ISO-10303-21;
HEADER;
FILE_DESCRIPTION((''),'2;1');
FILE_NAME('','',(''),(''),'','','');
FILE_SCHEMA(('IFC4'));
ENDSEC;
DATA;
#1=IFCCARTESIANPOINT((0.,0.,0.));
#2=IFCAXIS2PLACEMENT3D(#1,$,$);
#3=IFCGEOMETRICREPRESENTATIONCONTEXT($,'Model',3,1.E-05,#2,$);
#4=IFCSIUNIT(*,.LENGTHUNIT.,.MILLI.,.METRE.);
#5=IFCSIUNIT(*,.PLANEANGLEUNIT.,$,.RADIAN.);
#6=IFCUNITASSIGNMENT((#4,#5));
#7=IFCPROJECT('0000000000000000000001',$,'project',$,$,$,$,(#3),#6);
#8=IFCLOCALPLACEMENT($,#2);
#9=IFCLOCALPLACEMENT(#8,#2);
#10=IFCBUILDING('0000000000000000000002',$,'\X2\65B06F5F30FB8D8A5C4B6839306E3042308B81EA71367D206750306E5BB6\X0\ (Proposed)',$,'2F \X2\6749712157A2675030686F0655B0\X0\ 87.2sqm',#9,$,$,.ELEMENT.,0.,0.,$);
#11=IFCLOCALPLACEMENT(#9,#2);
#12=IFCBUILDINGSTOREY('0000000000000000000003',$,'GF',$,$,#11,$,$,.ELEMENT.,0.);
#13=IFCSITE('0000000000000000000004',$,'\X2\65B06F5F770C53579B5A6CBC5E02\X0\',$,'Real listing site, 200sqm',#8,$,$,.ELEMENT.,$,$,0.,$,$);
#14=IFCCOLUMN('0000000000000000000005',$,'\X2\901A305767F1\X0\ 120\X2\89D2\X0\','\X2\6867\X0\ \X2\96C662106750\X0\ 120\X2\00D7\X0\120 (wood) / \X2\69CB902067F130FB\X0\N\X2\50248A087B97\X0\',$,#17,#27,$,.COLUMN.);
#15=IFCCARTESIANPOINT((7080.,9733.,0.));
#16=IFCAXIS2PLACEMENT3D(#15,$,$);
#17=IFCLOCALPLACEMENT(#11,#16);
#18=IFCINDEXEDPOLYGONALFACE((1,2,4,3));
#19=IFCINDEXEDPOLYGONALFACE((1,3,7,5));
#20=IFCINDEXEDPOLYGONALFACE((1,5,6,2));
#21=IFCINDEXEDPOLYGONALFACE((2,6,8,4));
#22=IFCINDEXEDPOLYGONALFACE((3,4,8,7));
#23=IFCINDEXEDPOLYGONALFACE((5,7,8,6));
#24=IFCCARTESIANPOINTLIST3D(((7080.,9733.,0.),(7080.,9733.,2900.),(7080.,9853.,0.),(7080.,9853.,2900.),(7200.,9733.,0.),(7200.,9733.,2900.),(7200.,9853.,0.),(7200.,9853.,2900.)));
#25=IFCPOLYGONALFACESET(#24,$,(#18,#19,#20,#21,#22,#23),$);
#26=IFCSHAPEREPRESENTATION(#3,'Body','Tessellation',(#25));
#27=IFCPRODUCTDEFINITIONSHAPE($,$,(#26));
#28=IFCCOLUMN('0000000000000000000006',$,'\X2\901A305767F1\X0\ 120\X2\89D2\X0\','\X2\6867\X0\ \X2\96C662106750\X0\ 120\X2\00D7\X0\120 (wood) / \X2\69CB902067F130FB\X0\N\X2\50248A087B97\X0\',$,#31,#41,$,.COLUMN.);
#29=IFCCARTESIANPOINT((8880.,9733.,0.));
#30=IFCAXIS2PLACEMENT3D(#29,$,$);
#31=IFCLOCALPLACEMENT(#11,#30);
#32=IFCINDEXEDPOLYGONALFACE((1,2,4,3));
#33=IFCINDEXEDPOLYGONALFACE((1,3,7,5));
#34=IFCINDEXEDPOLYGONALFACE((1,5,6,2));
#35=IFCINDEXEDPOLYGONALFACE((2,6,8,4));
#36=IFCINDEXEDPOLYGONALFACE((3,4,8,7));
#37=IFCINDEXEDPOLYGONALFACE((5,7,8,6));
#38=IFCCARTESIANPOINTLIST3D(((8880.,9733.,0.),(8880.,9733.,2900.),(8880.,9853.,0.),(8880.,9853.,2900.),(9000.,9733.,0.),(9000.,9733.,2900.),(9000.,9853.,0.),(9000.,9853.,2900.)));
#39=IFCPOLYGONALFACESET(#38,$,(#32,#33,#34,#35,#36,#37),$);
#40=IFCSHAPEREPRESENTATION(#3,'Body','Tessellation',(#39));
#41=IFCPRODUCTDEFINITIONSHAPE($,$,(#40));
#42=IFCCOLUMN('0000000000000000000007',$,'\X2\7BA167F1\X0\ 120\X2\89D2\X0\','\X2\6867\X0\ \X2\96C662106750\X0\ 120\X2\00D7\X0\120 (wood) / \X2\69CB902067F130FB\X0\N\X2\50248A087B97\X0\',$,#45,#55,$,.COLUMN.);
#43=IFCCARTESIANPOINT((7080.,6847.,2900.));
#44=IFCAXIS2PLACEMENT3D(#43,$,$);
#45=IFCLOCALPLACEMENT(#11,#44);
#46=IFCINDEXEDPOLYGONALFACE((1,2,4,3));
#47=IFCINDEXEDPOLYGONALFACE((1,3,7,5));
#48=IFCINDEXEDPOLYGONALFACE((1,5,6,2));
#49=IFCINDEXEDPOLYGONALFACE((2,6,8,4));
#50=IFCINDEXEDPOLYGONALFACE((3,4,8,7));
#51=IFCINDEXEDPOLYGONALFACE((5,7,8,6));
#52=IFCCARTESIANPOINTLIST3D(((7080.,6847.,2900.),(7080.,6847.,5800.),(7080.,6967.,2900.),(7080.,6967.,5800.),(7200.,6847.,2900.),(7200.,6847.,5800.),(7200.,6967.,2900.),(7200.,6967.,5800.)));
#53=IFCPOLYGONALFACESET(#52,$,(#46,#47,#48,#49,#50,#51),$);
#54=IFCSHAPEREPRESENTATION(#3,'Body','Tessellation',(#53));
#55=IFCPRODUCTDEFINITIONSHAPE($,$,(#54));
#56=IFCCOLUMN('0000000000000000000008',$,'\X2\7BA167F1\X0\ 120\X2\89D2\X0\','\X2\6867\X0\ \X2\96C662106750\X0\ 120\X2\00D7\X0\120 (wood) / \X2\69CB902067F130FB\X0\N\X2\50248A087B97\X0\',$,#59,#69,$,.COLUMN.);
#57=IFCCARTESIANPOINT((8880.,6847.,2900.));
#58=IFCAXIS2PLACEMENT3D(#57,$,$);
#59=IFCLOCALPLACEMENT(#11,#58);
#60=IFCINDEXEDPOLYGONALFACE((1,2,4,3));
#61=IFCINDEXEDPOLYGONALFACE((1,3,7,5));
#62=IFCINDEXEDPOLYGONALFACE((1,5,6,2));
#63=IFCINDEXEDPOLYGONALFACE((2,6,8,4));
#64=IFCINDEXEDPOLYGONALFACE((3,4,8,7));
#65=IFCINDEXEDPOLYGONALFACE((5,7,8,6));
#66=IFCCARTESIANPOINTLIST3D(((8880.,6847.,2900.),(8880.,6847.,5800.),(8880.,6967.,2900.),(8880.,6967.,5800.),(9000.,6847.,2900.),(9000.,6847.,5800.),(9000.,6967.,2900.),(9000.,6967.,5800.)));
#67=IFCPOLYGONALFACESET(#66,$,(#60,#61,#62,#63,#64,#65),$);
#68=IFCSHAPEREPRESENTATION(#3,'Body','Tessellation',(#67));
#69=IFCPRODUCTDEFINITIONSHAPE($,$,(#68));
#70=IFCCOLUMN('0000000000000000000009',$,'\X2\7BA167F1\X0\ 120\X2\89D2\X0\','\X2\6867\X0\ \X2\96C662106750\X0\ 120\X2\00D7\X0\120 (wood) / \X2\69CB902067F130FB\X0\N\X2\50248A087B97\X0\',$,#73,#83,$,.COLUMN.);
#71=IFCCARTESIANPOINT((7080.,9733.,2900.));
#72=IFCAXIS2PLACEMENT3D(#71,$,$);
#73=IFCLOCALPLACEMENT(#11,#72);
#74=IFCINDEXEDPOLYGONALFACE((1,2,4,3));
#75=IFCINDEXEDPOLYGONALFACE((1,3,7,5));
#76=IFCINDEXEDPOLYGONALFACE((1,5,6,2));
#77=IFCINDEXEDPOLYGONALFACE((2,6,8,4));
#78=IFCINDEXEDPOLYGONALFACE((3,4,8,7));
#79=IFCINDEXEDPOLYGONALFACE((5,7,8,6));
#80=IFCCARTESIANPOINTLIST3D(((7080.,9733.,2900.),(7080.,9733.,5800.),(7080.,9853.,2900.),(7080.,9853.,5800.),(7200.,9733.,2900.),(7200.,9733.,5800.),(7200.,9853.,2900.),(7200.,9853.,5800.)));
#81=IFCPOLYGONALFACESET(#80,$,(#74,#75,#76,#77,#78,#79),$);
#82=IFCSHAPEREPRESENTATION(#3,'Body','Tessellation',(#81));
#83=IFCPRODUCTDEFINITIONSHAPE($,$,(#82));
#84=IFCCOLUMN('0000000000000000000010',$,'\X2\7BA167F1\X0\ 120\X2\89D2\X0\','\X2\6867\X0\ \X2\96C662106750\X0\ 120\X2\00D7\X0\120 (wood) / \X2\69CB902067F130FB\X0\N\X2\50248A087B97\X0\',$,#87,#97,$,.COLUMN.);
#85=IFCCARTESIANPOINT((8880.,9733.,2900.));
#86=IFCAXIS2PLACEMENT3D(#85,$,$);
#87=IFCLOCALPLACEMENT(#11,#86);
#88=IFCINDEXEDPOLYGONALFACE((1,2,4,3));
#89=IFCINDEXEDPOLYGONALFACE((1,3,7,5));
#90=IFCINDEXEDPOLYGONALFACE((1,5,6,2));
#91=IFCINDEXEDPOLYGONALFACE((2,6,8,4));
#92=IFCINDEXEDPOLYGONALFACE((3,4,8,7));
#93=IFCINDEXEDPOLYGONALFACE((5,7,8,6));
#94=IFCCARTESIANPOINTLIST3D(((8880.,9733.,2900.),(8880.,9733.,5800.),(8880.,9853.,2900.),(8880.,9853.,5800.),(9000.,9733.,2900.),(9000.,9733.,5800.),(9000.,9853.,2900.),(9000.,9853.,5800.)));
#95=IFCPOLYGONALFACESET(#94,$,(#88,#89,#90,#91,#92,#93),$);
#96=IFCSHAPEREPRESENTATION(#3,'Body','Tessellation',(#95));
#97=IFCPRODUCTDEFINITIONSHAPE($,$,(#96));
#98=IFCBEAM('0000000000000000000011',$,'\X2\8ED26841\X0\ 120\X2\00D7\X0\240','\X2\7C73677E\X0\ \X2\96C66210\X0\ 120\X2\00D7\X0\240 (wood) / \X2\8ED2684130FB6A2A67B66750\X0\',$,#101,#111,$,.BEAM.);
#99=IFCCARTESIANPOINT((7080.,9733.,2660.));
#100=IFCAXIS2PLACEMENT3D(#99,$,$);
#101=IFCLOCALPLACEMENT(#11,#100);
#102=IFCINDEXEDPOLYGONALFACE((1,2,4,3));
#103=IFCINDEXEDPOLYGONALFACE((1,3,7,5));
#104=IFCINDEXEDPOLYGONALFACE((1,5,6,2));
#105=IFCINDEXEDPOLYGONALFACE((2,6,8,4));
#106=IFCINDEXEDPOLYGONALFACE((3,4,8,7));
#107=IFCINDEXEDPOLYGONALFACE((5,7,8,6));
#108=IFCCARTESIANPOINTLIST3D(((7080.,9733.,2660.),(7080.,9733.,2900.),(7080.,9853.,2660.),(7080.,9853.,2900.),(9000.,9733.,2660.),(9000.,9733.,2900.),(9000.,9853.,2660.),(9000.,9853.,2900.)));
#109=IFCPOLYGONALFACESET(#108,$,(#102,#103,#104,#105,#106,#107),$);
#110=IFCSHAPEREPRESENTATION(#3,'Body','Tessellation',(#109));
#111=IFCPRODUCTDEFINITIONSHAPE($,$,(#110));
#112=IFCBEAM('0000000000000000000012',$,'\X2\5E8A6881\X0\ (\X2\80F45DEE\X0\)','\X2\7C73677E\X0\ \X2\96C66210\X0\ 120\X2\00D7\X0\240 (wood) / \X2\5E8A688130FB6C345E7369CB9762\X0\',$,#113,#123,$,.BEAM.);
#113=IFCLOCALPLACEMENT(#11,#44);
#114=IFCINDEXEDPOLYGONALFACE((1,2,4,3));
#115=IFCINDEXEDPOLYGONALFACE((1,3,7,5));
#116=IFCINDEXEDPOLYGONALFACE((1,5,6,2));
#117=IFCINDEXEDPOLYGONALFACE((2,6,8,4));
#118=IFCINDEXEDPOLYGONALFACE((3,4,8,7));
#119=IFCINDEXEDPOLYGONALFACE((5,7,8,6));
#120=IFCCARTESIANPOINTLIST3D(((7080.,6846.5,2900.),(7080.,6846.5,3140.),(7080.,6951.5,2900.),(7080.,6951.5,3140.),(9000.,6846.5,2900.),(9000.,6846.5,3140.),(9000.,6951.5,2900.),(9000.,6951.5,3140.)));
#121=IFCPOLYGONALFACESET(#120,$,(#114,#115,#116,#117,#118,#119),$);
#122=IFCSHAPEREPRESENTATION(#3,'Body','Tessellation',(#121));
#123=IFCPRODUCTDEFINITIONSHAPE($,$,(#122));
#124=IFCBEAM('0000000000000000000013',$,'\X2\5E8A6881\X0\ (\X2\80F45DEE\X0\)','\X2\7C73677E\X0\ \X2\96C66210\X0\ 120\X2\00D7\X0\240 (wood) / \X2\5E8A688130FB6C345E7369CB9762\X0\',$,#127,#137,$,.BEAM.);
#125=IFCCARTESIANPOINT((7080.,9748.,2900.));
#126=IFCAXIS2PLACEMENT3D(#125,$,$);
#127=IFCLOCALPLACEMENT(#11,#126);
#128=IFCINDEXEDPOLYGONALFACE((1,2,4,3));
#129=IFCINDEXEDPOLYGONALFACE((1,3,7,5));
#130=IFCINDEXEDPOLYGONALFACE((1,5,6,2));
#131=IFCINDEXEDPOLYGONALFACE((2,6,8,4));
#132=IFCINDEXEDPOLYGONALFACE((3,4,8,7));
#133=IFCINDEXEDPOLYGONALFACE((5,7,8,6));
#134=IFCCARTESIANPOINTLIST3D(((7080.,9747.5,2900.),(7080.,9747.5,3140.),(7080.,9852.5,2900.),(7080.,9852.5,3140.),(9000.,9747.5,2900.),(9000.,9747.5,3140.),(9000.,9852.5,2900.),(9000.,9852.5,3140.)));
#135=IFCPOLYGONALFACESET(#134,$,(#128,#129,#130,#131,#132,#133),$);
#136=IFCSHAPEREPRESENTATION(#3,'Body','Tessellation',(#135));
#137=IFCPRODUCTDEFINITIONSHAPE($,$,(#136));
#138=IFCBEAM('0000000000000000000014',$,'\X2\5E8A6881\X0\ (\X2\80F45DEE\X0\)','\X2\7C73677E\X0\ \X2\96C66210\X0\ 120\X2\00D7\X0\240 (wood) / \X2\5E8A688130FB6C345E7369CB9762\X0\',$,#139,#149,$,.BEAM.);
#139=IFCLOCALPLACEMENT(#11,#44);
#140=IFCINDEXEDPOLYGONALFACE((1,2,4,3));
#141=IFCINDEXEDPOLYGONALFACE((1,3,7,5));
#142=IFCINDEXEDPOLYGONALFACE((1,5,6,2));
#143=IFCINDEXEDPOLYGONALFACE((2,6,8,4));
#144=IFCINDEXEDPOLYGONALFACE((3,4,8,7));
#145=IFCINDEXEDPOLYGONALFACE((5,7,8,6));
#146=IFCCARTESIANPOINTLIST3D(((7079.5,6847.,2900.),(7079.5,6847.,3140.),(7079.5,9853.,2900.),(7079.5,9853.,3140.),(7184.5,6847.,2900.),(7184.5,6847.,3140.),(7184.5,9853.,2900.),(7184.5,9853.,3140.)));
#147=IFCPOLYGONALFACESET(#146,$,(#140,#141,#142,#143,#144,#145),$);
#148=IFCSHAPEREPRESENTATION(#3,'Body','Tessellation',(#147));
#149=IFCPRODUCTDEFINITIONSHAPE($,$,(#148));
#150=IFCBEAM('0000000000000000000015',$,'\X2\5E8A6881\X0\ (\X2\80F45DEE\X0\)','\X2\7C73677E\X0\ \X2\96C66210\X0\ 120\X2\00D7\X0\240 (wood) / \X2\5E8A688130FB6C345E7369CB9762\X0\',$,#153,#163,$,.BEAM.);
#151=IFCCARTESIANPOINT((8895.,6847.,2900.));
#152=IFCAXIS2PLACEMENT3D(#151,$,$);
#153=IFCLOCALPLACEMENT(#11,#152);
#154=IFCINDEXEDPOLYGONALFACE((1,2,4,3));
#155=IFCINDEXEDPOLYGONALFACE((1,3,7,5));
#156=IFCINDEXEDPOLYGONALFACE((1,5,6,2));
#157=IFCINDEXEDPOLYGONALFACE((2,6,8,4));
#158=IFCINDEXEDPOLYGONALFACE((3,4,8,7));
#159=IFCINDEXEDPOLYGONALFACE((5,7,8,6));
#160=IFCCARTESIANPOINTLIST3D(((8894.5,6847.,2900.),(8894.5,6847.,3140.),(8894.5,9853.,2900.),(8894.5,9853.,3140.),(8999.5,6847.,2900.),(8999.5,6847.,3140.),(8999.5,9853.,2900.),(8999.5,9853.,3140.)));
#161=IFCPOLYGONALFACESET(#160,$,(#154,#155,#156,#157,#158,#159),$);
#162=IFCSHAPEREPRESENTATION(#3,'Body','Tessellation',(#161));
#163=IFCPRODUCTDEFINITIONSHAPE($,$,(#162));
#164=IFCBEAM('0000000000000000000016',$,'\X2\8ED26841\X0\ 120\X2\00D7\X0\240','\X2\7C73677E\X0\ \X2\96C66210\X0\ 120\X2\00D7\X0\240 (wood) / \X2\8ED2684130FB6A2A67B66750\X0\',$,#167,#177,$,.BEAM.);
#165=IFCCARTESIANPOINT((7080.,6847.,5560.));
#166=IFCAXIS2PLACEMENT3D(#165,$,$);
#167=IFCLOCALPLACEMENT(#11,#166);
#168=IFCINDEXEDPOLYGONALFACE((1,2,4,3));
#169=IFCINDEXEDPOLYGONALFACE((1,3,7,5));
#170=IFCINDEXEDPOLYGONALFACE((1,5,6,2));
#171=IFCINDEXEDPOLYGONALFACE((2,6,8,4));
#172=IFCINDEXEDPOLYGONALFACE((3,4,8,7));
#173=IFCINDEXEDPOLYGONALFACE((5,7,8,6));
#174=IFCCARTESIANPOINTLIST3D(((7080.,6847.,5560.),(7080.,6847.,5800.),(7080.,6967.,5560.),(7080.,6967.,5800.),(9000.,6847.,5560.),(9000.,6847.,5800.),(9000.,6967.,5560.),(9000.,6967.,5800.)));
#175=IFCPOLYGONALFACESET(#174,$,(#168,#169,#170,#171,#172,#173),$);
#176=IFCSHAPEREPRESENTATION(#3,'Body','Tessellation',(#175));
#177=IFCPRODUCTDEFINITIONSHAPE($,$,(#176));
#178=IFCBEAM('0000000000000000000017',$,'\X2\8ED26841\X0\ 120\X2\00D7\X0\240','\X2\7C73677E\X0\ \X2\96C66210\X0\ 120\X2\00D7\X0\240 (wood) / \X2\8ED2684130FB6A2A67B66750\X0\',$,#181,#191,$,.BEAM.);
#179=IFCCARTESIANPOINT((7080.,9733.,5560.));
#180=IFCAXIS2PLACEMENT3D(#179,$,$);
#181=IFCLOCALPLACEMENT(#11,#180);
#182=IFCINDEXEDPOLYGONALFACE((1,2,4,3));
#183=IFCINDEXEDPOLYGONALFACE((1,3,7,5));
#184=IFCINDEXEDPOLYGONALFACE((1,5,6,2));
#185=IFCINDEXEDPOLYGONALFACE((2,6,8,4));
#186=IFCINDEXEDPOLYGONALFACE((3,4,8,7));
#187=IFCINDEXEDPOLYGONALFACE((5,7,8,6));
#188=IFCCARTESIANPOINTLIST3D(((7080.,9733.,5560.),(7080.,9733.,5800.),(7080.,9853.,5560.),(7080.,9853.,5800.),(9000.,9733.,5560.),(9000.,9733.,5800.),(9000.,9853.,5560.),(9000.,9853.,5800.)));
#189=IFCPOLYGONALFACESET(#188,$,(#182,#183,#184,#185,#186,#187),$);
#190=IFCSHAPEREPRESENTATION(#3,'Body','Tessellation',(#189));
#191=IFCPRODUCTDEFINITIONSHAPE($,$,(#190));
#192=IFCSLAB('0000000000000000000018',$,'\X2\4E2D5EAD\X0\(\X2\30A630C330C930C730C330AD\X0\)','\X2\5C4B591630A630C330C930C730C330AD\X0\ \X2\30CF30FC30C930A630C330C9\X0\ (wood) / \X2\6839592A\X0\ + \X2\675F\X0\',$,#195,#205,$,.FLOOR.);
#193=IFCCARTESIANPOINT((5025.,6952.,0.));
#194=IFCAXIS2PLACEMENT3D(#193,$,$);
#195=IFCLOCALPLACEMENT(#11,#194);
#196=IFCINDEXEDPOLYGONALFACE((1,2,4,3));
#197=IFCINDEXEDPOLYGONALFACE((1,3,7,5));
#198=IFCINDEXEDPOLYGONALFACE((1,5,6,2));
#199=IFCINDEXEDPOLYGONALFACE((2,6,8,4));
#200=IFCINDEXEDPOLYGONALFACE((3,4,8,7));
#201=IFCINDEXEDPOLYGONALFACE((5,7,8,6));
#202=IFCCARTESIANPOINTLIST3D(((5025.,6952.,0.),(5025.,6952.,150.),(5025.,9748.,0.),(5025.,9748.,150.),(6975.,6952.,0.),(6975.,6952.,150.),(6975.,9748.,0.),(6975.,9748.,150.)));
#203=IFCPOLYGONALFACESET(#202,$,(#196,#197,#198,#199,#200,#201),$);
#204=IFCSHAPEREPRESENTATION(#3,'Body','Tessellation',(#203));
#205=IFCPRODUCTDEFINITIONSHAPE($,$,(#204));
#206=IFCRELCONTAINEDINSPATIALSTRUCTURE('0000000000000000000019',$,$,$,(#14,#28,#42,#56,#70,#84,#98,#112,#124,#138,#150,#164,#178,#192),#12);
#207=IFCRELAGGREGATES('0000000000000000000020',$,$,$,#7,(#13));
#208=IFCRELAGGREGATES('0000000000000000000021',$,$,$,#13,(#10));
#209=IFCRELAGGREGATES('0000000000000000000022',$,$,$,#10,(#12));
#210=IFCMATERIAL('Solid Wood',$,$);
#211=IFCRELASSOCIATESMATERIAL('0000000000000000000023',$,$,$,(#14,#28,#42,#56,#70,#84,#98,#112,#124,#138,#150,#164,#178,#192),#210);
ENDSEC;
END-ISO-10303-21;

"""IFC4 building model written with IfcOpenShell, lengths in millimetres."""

from ifc_helpers import new_model, si_unit, frame, frame_2d, origin, place, context, project, spatial, rectangle, extrude, material, element, save


model = new_model("IFC4")

# Units and contexts
model_context = context("Model", 3, precision=1e-05, world=origin())
ifc_project = project(units=[si_unit("LENGTHUNIT", "METRE", prefix="MILLI"), si_unit("PLANEANGLEUNIT", "RADIAN")], contexts=[model_context])

# Site, building, storey
site_placement = place(None, origin())
site = spatial("IfcSite", under=ifc_project, at=site_placement, Name="新潟県南魚沼市", ObjectType="Real listing site, 200sqm", CompositionType="ELEMENT", RefElevation=0.0)
building_placement = place(site_placement, origin())
building = spatial("IfcBuilding", under=site, at=building_placement, Name="新潟・越屋根のある自然素材の家 (Proposed)", ObjectType="2F 杉無垢材と漆喰 87.2sqm", CompositionType="ELEMENT", ElevationOfRefHeight=0.0, ElevationOfTerrain=0.0)
storey_placement = place(building_placement, origin())
storey = spatial("IfcBuildingStorey", under=building, at=storey_placement, Name="GF", CompositionType="ELEMENT", Elevation=0.0)

# Columns
ifc_material_1 = material(Name="Solid Wood")
column_1_placement = place(storey_placement, frame((7080.0, 9733.0, 0.0)))
element("IfcColumn", 1, at=column_1_placement, inside=storey, material=ifc_material_1, Name="通し柱 120角", Description="桧 集成材 120×120 (wood) / 構造柱・N値計算", PredefinedType="COLUMN", context=model_context, shape_type="SweptSolid", body=[
    extrude(rectangle(XDim=120.0, YDim=120.0, at=frame_2d((60.0, 60.0))), frame((7080.0, 9733.0, 0.0)), (0.0, 0.0, 1.0), 2900.0),
])
column_2_placement = place(storey_placement, frame((8880.0, 9733.0, 0.0)))
element("IfcColumn", 2, at=column_2_placement, inside=storey, material=ifc_material_1, Name="通し柱 120角", Description="桧 集成材 120×120 (wood) / 構造柱・N値計算", PredefinedType="COLUMN", context=model_context, shape_type="SweptSolid", body=[
    extrude(rectangle(XDim=120.0, YDim=120.0, at=frame_2d((60.0, 60.0))), frame((8880.0, 9733.0, 0.0)), (0.0, 0.0, 1.0), 2900.0),
])
column_3_placement = place(storey_placement, frame((7080.0, 6847.0, 2900.0)))
element("IfcColumn", 3, at=column_3_placement, inside=storey, material=ifc_material_1, Name="管柱 120角", Description="桧 集成材 120×120 (wood) / 構造柱・N値計算", PredefinedType="COLUMN", context=model_context, shape_type="SweptSolid", body=[
    extrude(rectangle(XDim=120.0, YDim=120.0, at=frame_2d((60.0, 60.0))), frame((7080.0, 6847.0, 2900.0)), (0.0, 0.0, 1.0), 2900.0),
])
column_4_placement = place(storey_placement, frame((8880.0, 6847.0, 2900.0)))
element("IfcColumn", 4, at=column_4_placement, inside=storey, material=ifc_material_1, Name="管柱 120角", Description="桧 集成材 120×120 (wood) / 構造柱・N値計算", PredefinedType="COLUMN", context=model_context, shape_type="SweptSolid", body=[
    extrude(rectangle(XDim=120.0, YDim=120.0, at=frame_2d((60.0, 60.0))), frame((8880.0, 6847.0, 2900.0)), (0.0, 0.0, 1.0), 2900.0),
])
column_5_placement = place(storey_placement, frame((7080.0, 9733.0, 2900.0)))
element("IfcColumn", 5, at=column_5_placement, inside=storey, material=ifc_material_1, Name="管柱 120角", Description="桧 集成材 120×120 (wood) / 構造柱・N値計算", PredefinedType="COLUMN", context=model_context, shape_type="SweptSolid", body=[
    extrude(rectangle(XDim=120.0, YDim=120.0, at=frame_2d((60.0, 60.0))), frame((7080.0, 9733.0, 2900.0)), (0.0, 0.0, 1.0), 2900.0),
])
column_6_placement = place(storey_placement, frame((8880.0, 9733.0, 2900.0)))
element("IfcColumn", 6, at=column_6_placement, inside=storey, material=ifc_material_1, Name="管柱 120角", Description="桧 集成材 120×120 (wood) / 構造柱・N値計算", PredefinedType="COLUMN", context=model_context, shape_type="SweptSolid", body=[
    extrude(rectangle(XDim=120.0, YDim=120.0, at=frame_2d((60.0, 60.0))), frame((8880.0, 9733.0, 2900.0)), (0.0, 0.0, 1.0), 2900.0),
])

# Beams
beam_1_placement = place(storey_placement, frame((7080.0, 9733.0, 2660.0)))
element("IfcBeam", 7, at=beam_1_placement, inside=storey, material=ifc_material_1, Name="軒桁 120×240", Description="米松 集成 120×240 (wood) / 軒桁・横架材", PredefinedType="BEAM", context=model_context, shape_type="SweptSolid", body=[
    extrude(rectangle(XDim=1920.0, YDim=120.0, at=frame_2d((960.0, 60.0))), frame((7080.0, 9733.0, 2660.0)), (0.0, 0.0, 1.0), 240.0),
])
beam_2_placement = place(storey_placement, frame((7080.0, 6847.0, 2900.0)))
element("IfcBeam", 8, at=beam_2_placement, inside=storey, material=ifc_material_1, Name="床梁 (胴差)", Description="米松 集成 120×240 (wood) / 床梁・水平構面", PredefinedType="BEAM", context=model_context, shape_type="SweptSolid", body=[
    extrude(rectangle(XDim=1920.0, YDim=105.0, at=frame_2d((960.0, 52.0))), frame((7080.0, 6847.0, 2900.0)), (0.0, 0.0, 1.0), 240.0),
])
beam_3_placement = place(storey_placement, frame((7080.0, 9748.0, 2900.0)))
element("IfcBeam", 9, at=beam_3_placement, inside=storey, material=ifc_material_1, Name="床梁 (胴差)", Description="米松 集成 120×240 (wood) / 床梁・水平構面", PredefinedType="BEAM", context=model_context, shape_type="SweptSolid", body=[
    extrude(rectangle(XDim=1920.0, YDim=105.0, at=frame_2d((960.0, 52.0))), frame((7080.0, 9748.0, 2900.0)), (0.0, 0.0, 1.0), 240.0),
])
beam_4_placement = place(storey_placement, frame((7080.0, 6847.0, 2900.0)))
element("IfcBeam", 10, at=beam_4_placement, inside=storey, material=ifc_material_1, Name="床梁 (胴差)", Description="米松 集成 120×240 (wood) / 床梁・水平構面", PredefinedType="BEAM", context=model_context, shape_type="SweptSolid", body=[
    extrude(rectangle(XDim=105.0, YDim=3006.0, at=frame_2d((52.0, 1503.0))), frame((7080.0, 6847.0, 2900.0)), (0.0, 0.0, 1.0), 240.0),
])
beam_5_placement = place(storey_placement, frame((8895.0, 6847.0, 2900.0)))
element("IfcBeam", 11, at=beam_5_placement, inside=storey, material=ifc_material_1, Name="床梁 (胴差)", Description="米松 集成 120×240 (wood) / 床梁・水平構面", PredefinedType="BEAM", context=model_context, shape_type="SweptSolid", body=[
    extrude(rectangle(XDim=105.0, YDim=3006.0, at=frame_2d((52.0, 1503.0))), frame((8895.0, 6847.0, 2900.0)), (0.0, 0.0, 1.0), 240.0),
])
beam_6_placement = place(storey_placement, frame((7080.0, 6847.0, 5560.0)))
element("IfcBeam", 12, at=beam_6_placement, inside=storey, material=ifc_material_1, Name="軒桁 120×240", Description="米松 集成 120×240 (wood) / 軒桁・横架材", PredefinedType="BEAM", context=model_context, shape_type="SweptSolid", body=[
    extrude(rectangle(XDim=1920.0, YDim=120.0, at=frame_2d((960.0, 60.0))), frame((7080.0, 6847.0, 5560.0)), (0.0, 0.0, 1.0), 240.0),
])
beam_7_placement = place(storey_placement, frame((7080.0, 9733.0, 5560.0)))
element("IfcBeam", 13, at=beam_7_placement, inside=storey, material=ifc_material_1, Name="軒桁 120×240", Description="米松 集成 120×240 (wood) / 軒桁・横架材", PredefinedType="BEAM", context=model_context, shape_type="SweptSolid", body=[
    extrude(rectangle(XDim=1920.0, YDim=120.0, at=frame_2d((960.0, 60.0))), frame((7080.0, 9733.0, 5560.0)), (0.0, 0.0, 1.0), 240.0),
])

# Slab
slab_placement = place(storey_placement, frame((5025.0, 6952.0, 0.0)))
element("IfcSlab", 14, at=slab_placement, inside=storey, material=ifc_material_1, Name="中庭(ウッドデッキ)", Description="屋外ウッドデッキ ハードウッド (wood) / 根太 + 束", PredefinedType="FLOOR", context=model_context, shape_type="SweptSolid", body=[
    extrude(rectangle(XDim=1950.0, YDim=2796.0, at=frame_2d((975.0, 1398.0))), frame((5025.0, 6952.0, 0.0)), (0.0, 0.0, 1.0), 150.0),
])

save(model, "model.ifc")
